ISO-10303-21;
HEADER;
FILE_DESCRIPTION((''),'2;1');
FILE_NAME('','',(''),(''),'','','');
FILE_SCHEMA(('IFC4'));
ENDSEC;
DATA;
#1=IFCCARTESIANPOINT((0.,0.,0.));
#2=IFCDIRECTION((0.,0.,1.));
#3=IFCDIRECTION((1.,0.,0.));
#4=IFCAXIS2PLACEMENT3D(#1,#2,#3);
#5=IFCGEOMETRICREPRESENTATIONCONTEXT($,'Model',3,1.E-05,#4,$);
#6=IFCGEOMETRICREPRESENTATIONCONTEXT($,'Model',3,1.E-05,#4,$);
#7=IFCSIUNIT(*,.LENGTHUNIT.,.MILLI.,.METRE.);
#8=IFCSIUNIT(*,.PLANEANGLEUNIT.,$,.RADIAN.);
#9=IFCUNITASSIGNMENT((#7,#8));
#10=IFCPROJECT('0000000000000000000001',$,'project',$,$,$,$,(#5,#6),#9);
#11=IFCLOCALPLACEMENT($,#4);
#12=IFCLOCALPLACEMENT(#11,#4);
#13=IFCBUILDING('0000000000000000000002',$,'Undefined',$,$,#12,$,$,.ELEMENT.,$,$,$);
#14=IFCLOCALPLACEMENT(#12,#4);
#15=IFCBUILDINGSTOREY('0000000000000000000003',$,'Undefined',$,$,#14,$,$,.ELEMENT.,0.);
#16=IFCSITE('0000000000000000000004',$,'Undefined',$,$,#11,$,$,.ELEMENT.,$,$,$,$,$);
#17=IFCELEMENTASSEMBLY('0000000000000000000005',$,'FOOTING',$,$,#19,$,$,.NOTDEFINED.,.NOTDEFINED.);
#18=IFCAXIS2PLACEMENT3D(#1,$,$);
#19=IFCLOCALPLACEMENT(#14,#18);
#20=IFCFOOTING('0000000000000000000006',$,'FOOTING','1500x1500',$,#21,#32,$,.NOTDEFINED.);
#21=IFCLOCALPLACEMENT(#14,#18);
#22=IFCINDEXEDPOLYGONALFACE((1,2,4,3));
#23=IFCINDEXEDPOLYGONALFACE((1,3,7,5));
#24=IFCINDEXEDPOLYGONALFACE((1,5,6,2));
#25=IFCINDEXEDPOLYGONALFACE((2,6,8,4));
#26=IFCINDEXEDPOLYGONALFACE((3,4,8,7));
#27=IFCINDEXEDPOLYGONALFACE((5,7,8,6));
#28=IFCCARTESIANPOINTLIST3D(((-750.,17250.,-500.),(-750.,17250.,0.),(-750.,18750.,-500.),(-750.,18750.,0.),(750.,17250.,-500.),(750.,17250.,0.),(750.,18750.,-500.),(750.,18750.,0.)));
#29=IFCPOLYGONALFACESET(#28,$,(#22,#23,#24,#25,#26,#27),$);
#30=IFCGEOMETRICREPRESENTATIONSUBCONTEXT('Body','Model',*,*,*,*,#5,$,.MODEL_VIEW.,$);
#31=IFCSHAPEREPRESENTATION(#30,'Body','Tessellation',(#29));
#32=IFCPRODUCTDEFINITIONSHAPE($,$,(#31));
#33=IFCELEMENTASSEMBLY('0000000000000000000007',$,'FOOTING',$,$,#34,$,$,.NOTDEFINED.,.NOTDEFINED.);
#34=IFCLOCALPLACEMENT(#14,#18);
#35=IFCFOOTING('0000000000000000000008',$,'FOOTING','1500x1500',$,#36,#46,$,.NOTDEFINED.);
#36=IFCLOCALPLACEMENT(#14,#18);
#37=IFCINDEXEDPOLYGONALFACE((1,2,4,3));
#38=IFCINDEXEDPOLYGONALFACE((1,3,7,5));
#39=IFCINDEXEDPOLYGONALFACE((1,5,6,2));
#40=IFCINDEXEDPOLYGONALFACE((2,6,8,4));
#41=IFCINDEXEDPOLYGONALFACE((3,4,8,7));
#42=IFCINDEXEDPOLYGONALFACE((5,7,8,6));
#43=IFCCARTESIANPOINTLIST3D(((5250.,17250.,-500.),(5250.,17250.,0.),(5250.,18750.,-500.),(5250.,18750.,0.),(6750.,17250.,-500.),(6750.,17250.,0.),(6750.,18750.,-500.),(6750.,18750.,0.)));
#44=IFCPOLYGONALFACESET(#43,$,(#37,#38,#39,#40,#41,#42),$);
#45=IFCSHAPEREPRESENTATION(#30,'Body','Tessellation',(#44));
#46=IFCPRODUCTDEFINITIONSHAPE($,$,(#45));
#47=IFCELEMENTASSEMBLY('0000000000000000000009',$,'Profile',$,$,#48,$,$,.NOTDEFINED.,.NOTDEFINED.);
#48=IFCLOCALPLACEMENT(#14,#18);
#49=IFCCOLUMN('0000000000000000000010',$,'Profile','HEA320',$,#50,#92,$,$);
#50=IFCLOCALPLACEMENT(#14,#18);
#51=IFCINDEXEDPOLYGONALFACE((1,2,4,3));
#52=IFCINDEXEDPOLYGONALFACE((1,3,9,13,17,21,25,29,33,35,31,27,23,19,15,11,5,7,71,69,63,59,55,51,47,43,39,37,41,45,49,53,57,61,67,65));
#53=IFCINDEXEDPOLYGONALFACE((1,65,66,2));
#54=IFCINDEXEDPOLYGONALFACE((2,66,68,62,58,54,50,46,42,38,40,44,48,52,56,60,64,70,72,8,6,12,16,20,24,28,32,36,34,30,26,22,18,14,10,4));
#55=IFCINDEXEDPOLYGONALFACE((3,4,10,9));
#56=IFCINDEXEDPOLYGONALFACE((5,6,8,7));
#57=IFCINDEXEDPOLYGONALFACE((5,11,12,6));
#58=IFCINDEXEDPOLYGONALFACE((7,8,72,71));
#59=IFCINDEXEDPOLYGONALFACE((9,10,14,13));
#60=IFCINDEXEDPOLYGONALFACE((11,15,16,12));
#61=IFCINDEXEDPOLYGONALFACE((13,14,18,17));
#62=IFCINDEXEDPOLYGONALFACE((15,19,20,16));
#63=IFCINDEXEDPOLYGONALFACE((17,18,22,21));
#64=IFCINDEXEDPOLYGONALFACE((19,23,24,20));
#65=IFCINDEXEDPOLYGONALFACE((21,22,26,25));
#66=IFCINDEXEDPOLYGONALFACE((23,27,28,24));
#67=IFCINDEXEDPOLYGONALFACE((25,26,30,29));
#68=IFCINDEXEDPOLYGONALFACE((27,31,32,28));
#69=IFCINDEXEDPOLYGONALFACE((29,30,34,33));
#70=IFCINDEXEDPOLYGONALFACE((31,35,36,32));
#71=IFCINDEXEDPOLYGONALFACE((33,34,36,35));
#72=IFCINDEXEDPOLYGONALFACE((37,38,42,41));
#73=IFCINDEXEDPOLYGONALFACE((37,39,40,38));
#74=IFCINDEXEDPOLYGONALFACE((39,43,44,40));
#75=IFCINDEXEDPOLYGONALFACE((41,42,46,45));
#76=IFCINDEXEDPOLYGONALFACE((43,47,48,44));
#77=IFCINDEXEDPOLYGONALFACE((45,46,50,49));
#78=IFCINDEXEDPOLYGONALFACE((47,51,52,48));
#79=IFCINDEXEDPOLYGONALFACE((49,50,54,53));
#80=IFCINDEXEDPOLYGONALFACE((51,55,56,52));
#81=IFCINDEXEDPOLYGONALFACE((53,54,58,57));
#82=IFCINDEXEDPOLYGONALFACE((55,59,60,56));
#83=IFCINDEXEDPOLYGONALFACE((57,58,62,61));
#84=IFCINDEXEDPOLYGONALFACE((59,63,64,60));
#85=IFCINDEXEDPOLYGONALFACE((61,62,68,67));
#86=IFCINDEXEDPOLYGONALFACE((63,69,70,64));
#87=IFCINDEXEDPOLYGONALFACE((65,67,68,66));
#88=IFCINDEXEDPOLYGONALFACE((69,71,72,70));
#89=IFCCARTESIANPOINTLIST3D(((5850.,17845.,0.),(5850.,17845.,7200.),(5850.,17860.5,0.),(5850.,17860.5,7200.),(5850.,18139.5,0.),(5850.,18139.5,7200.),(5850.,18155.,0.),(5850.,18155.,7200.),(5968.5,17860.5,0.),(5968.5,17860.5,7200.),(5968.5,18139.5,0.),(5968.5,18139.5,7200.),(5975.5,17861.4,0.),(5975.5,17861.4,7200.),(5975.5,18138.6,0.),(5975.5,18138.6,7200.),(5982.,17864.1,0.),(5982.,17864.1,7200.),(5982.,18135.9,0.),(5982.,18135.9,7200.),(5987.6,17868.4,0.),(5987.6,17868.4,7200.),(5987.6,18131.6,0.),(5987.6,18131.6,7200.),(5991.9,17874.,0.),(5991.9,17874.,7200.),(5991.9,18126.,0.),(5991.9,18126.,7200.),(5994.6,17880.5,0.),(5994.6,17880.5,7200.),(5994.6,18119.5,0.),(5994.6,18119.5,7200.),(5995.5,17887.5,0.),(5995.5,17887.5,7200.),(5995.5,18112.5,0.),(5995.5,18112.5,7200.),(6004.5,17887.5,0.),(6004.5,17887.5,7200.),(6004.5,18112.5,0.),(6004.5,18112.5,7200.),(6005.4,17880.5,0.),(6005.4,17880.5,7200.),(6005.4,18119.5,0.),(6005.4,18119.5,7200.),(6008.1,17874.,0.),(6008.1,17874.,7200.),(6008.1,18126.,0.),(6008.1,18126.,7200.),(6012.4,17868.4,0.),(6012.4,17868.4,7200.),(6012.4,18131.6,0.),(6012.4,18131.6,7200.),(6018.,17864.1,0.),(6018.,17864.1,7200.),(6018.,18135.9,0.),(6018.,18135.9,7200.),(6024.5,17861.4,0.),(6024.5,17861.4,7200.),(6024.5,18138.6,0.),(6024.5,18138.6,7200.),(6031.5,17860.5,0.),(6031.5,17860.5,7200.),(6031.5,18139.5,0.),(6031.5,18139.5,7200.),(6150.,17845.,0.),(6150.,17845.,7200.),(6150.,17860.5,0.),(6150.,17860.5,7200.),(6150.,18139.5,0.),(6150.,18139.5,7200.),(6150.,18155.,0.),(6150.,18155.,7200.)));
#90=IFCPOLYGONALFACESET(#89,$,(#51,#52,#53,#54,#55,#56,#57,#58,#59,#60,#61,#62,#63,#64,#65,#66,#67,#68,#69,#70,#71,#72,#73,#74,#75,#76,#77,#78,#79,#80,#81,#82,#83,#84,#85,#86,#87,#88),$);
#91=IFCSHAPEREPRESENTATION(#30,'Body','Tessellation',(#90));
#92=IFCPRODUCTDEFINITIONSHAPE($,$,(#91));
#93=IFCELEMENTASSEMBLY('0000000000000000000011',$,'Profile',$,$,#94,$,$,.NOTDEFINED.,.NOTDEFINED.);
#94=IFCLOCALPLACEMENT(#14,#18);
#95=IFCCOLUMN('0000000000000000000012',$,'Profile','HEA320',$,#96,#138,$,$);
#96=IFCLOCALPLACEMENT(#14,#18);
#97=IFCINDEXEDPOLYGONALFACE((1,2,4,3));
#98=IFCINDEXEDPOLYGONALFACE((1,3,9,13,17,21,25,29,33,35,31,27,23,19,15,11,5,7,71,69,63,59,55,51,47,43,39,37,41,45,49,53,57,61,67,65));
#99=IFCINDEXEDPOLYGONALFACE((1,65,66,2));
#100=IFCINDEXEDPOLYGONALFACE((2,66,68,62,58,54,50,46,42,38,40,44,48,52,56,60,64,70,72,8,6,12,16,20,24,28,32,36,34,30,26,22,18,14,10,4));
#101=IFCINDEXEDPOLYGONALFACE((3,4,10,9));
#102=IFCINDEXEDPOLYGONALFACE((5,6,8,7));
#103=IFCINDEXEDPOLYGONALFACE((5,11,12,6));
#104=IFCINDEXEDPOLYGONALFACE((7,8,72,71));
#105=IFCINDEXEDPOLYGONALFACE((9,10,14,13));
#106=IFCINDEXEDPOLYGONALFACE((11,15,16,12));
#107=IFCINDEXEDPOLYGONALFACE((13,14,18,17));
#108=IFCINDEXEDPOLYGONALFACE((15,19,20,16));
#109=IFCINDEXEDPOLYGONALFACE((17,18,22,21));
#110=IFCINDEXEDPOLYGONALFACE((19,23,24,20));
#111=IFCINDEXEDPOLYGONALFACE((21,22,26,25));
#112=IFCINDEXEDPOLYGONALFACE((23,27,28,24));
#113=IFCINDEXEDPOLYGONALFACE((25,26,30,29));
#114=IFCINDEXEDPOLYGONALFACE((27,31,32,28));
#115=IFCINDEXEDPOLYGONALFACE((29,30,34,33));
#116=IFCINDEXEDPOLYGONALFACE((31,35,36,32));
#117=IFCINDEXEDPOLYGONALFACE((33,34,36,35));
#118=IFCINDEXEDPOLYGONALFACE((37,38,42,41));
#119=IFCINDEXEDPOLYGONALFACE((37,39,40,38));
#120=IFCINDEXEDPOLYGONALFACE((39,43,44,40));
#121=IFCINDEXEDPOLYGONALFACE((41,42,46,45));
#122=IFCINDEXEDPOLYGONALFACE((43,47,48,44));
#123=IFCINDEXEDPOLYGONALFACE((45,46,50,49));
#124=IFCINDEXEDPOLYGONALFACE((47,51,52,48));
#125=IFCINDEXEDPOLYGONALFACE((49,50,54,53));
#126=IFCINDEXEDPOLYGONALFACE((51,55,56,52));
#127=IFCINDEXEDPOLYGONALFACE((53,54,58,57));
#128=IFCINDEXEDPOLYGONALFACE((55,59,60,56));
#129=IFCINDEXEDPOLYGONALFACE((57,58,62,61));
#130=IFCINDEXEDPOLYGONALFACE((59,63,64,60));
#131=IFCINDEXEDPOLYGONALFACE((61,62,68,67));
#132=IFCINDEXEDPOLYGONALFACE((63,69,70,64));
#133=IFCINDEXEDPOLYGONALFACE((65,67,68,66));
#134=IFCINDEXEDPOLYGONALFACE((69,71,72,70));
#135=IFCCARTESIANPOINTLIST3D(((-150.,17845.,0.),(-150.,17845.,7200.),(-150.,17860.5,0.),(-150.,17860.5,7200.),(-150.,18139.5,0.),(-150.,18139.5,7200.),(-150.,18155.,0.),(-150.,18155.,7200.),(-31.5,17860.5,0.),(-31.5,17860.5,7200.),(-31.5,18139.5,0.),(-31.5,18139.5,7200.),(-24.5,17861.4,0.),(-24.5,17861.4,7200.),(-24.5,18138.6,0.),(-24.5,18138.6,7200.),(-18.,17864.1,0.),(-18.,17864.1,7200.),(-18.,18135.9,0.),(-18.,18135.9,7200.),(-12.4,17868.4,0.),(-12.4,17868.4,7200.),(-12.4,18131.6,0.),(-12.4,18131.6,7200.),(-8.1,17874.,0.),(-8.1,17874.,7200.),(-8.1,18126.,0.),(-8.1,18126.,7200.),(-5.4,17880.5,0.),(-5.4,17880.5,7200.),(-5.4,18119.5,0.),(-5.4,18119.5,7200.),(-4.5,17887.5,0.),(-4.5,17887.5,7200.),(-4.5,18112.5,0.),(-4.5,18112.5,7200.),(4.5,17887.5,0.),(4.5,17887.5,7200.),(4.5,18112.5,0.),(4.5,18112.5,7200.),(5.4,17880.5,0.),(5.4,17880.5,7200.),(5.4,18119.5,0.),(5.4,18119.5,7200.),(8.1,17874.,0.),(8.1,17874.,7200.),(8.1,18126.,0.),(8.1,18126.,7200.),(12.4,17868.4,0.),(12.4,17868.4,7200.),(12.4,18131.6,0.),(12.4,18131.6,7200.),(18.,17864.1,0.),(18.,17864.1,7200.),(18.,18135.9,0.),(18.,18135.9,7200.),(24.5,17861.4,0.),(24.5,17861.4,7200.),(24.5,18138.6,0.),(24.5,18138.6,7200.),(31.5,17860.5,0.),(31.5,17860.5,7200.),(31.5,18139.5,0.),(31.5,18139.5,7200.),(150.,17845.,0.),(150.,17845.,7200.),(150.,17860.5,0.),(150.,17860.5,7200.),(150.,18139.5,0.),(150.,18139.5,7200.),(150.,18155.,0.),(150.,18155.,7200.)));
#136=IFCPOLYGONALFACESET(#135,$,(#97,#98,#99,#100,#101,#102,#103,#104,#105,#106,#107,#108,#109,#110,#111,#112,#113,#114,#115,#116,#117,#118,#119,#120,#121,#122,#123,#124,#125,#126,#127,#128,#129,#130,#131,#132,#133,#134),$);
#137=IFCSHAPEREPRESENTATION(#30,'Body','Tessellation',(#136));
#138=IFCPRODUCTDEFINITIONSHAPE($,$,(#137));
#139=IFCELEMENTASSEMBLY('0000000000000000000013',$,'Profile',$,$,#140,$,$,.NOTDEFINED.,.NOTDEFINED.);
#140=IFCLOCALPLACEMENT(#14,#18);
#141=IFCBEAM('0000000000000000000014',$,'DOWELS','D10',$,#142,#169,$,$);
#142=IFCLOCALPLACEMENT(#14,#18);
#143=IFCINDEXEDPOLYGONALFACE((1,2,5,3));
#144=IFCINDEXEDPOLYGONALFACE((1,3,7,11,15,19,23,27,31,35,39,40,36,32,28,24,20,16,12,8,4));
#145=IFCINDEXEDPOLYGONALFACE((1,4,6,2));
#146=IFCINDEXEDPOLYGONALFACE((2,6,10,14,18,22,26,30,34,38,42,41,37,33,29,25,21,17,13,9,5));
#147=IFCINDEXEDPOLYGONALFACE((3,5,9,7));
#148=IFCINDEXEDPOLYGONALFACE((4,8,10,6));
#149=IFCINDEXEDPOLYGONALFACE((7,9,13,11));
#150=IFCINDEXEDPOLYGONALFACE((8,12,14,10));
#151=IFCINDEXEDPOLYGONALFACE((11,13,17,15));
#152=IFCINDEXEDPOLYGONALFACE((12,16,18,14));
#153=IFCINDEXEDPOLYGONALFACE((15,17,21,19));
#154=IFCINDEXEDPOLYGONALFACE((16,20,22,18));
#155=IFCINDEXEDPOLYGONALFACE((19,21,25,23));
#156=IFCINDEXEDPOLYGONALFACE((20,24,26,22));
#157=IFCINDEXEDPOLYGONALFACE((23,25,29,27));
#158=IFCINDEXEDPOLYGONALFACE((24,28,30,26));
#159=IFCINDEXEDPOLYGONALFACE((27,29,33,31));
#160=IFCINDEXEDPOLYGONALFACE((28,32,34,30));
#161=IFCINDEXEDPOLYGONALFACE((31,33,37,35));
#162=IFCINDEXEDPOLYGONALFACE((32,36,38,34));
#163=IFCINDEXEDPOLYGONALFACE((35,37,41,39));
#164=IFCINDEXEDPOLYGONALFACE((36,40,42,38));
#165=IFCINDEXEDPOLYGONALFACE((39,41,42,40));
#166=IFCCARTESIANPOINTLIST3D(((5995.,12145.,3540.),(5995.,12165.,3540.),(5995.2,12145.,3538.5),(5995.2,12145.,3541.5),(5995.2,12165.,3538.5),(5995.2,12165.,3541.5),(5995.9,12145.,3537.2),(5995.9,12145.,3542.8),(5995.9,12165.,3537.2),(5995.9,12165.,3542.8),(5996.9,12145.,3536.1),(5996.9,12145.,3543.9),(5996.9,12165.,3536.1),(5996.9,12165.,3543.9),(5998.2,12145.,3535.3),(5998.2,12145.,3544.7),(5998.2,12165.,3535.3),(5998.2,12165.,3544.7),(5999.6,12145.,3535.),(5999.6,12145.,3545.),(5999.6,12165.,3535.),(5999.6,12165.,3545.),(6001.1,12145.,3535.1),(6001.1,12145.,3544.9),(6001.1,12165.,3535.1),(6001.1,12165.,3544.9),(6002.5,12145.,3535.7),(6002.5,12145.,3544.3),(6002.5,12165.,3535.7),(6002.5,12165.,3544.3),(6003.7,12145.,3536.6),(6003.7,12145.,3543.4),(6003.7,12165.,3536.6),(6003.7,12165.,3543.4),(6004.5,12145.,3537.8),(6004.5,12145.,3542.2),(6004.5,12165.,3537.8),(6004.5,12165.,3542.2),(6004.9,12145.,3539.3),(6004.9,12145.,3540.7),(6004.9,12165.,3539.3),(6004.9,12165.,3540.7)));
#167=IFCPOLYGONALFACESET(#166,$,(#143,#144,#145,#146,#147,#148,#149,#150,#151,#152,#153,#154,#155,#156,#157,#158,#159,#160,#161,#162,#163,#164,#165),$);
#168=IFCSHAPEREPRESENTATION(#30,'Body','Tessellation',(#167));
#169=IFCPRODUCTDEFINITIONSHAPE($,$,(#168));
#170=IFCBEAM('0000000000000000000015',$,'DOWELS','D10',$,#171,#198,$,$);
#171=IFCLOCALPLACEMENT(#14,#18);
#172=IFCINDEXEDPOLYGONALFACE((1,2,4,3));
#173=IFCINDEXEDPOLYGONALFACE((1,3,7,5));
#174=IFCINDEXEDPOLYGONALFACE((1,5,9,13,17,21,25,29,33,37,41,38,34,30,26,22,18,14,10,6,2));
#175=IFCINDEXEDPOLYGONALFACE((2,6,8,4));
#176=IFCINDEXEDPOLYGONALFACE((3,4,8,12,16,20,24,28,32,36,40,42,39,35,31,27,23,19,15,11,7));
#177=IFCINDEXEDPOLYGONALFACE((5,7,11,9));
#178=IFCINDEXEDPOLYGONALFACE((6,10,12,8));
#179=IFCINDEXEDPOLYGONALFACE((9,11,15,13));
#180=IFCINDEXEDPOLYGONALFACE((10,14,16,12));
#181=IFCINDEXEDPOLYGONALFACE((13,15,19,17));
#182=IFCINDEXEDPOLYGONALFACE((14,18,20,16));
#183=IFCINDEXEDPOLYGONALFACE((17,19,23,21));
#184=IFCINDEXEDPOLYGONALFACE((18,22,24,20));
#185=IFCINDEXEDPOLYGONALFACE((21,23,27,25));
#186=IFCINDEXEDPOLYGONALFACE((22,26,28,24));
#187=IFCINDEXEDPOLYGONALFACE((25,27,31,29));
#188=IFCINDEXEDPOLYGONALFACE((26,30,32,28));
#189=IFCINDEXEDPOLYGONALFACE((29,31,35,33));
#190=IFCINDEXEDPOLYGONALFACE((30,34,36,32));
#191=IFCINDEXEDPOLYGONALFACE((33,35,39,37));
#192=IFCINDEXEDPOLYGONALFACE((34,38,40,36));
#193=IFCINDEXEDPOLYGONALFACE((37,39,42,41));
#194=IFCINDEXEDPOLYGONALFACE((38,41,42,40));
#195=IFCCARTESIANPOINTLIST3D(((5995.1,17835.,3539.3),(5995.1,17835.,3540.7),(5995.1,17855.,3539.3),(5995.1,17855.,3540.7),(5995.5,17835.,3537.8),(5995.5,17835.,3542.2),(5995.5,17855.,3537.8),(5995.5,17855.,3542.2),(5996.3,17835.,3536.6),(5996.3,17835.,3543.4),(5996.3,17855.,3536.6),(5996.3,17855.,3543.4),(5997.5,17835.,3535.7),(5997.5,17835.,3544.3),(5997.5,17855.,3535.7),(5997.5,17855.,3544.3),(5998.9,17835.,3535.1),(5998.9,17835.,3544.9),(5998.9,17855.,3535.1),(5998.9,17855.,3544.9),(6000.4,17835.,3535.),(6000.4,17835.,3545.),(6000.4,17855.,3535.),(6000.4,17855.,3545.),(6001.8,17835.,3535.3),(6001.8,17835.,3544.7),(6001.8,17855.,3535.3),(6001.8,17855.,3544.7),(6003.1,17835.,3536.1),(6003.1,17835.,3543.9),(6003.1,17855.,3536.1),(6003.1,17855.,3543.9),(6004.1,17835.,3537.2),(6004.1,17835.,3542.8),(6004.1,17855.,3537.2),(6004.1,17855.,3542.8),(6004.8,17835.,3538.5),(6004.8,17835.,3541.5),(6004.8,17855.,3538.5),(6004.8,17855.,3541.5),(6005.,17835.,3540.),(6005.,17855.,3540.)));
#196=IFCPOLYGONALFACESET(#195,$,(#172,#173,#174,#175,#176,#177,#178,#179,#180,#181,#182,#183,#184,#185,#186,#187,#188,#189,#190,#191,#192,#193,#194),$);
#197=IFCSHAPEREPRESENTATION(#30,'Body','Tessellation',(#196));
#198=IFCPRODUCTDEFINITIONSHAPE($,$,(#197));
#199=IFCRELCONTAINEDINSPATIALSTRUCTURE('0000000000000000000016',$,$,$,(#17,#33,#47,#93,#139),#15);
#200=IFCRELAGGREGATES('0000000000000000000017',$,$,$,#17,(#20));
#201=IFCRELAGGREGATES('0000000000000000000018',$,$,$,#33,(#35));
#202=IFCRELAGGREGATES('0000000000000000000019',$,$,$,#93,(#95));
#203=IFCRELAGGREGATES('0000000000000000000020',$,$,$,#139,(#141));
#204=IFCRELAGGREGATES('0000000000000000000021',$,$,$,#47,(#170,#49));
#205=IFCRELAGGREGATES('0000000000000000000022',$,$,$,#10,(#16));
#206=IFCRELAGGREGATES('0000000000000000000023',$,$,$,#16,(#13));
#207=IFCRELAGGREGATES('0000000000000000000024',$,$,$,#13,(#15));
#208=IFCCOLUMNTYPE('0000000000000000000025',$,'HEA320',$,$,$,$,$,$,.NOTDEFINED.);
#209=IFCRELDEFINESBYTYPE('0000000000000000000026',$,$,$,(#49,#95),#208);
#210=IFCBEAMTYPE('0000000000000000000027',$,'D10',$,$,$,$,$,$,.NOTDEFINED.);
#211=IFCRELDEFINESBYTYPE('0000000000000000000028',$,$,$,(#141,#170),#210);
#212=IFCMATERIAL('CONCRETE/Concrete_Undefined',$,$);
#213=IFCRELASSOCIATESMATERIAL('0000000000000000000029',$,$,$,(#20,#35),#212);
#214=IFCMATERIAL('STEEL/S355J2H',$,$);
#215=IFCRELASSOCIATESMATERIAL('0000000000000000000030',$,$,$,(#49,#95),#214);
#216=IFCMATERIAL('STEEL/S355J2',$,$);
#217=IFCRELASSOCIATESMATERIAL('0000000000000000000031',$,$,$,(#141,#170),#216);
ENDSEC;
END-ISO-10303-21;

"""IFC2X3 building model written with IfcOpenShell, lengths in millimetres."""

from ifc_helpers import new_model, si_unit, frame, origin_with_axes, origin_2d_with_axis, place, context, subcontext, project, spatial, rectangle, circle, i_section, extrude, material, type_object, element, aggregate, save


model = new_model("IFC2X3")

# Units and contexts
model_context_1 = context("Model", 3, precision=1e-05, world=origin_with_axes())
model_context_2 = context("Model", 3, precision=1e-05, world=origin_with_axes())
body_context = subcontext(model_context_1, "Body", "Model", "MODEL_VIEW")
ifc_project = project(units=[si_unit("LENGTHUNIT", "METRE", prefix="MILLI"), si_unit("PLANEANGLEUNIT", "RADIAN")], contexts=[model_context_1, model_context_2])

# Site, building, storey
site_placement = place(None, origin_with_axes())
site = spatial("IfcSite", under=ifc_project, at=site_placement, Name="Undefined", CompositionType="ELEMENT")
building_placement = place(site_placement, origin_with_axes())
building = spatial("IfcBuilding", under=site, at=building_placement, Name="Undefined", CompositionType="ELEMENT")
storey_placement = place(building_placement, origin_with_axes())
storey = spatial("IfcBuildingStorey", under=building, at=storey_placement, Name="Undefined", CompositionType="ELEMENT", Elevation=0.0)

# Element assemblies, footings
assembly_1_placement = place(storey_placement, origin_with_axes())
assembly_1 = element("IfcElementAssembly", 1, at=assembly_1_placement, inside=storey, Name="FOOTING", AssemblyPlace="NOTDEFINED", PredefinedType="NOTDEFINED")
ifc_material_1 = material(Name="CONCRETE/Concrete_Undefined")
footing_1_placement = place(assembly_1_placement, frame((0.0, 18000.0, -500.0), z_axis=(0.0, 1.0, 0.0), x_axis=(0.0, 0.0, 1.0)))
footing_1 = element("IfcFooting", 2, at=footing_1_placement, material=ifc_material_1, Name="FOOTING", Description="1500x1500", PredefinedType="NOTDEFINED", context=body_context, shape_type="SweptSolid", body=[
    extrude(rectangle(XDim=1500.0, YDim=1500.0, at=origin_2d_with_axis()), frame((500.0, 0.0, 0.0), z_axis=(-1.0, 0.0, 0.0), x_axis=(0.0, -1.0, 0.0)), (0.0, 0.0, 1.0), 500.0),
])
aggregate(assembly_1, [footing_1])
assembly_2_placement = place(storey_placement, origin_with_axes())
assembly_2 = element("IfcElementAssembly", 3, at=assembly_2_placement, inside=storey, Name="FOOTING", AssemblyPlace="NOTDEFINED", PredefinedType="NOTDEFINED")
footing_2_placement = place(assembly_2_placement, frame((6000.0, 18000.0, -500.0), z_axis=(0.0, 1.0, 0.0), x_axis=(0.0, 0.0, 1.0)))
footing_2 = element("IfcFooting", 4, at=footing_2_placement, material=ifc_material_1, Name="FOOTING", Description="1500x1500", PredefinedType="NOTDEFINED", context=body_context, shape_type="SweptSolid", body=[
    extrude(rectangle(XDim=1500.0, YDim=1500.0, at=origin_2d_with_axis()), frame((500.0, 0.0, 0.0), z_axis=(-1.0, 0.0, 0.0), x_axis=(0.0, -1.0, 0.0)), (0.0, 0.0, 1.0), 500.0),
])
aggregate(assembly_2, [footing_2])

# Element assemblies, columns
assembly_3_placement = place(storey_placement, origin_with_axes())
assembly_3 = element("IfcElementAssembly", 5, at=assembly_3_placement, inside=storey, Name="Profile", AssemblyPlace="NOTDEFINED", PredefinedType="NOTDEFINED")
ifc_material_2 = material(Name="STEEL/S355J2H")
column_type = type_object("IfcColumnType", Name="HEA320", PredefinedType="NOTDEFINED")
column_1_placement = place(assembly_3_placement, frame((6000.0, 18000.0, 0.0), z_axis=(0.0, 0.0, 1.0), x_axis=(0.0, 1.0, 0.0)))
column_1 = element("IfcColumn", 6, at=column_1_placement, type_object=column_type, material=ifc_material_2, Name="Profile", Description="HEA320", context=body_context, shape_type="SweptSolid", body=[
    extrude(i_section(OverallWidth=300.0, OverallDepth=310.0, WebThickness=9.0, FlangeThickness=15.5, FilletRadius=27.0, at=origin_2d_with_axis()), frame((0.0, 0.0, 7200.0), z_axis=(0.0, 0.0, -1.0), x_axis=(0.0, 1.0, 0.0)), (0.0, 0.0, 1.0), 7200.0),
])
assembly_4_placement = place(storey_placement, origin_with_axes())
assembly_4 = element("IfcElementAssembly", 7, at=assembly_4_placement, inside=storey, Name="Profile", AssemblyPlace="NOTDEFINED", PredefinedType="NOTDEFINED")
column_2_placement = place(assembly_4_placement, frame((0.0, 18000.0, 0.0), z_axis=(0.0, 0.0, 1.0), x_axis=(0.0, 1.0, 0.0)))
column_2 = element("IfcColumn", 8, at=column_2_placement, type_object=column_type, material=ifc_material_2, Name="Profile", Description="HEA320", context=body_context, shape_type="SweptSolid", body=[
    extrude(i_section(OverallWidth=300.0, OverallDepth=310.0, WebThickness=9.0, FlangeThickness=15.5, FilletRadius=27.0, at=origin_2d_with_axis()), frame((0.0, 0.0, 7200.0), z_axis=(0.0, 0.0, -1.0), x_axis=(0.0, 1.0, 0.0)), (0.0, 0.0, 1.0), 7200.0),
])

# Element assembly, beam
assembly_5_placement = place(storey_placement, origin_with_axes())
assembly_5 = element("IfcElementAssembly", 9, at=assembly_5_placement, inside=storey, Name="Profile", AssemblyPlace="NOTDEFINED", PredefinedType="NOTDEFINED")
ifc_material_3 = material(Name="STEEL/S355J2")
beam_type_1 = type_object("IfcBeamType", Name="D10", PredefinedType="NOTDEFINED")
beam_1_placement = place(assembly_5_placement, frame((6000.0, 12165.0, 3540.0), z_axis=(0.0, 0.0, 1.0), x_axis=(0.0, -1.0, 0.0)))
beam_1 = element("IfcBeam", 10, at=beam_1_placement, type_object=beam_type_1, material=ifc_material_3, Name="DOWELS", Description="D10", context=body_context, shape_type="SweptSolid", body=[
    extrude(circle(Radius=5.0, at=origin_2d_with_axis()), frame((20.0, 0.0, 0.0), z_axis=(-1.0, 0.0, 0.0), x_axis=(0.0, -1.0, 0.0)), (0.0, 0.0, 1.0), 20.0),
])

# Beam
beam_2_placement = place(assembly_3_placement, frame((6000.0, 17835.0, 3540.0), z_axis=(0.0, 0.0, 1.0), x_axis=(0.0, 1.0, 0.0)))
beam_2 = element("IfcBeam", 11, at=beam_2_placement, type_object=beam_type_1, material=ifc_material_3, Name="DOWELS", Description="D10", context=body_context, shape_type="SweptSolid", body=[
    extrude(circle(Radius=5.0, at=origin_2d_with_axis()), frame((20.0, 0.0, 0.0), z_axis=(-1.0, 0.0, 0.0), x_axis=(0.0, -1.0, 0.0)), (0.0, 0.0, 1.0), 20.0),
])
aggregate(assembly_4, [column_2])

aggregate(assembly_5, [beam_1])
aggregate(assembly_3, [beam_2, column_1])

save(model, "model.ifc")
